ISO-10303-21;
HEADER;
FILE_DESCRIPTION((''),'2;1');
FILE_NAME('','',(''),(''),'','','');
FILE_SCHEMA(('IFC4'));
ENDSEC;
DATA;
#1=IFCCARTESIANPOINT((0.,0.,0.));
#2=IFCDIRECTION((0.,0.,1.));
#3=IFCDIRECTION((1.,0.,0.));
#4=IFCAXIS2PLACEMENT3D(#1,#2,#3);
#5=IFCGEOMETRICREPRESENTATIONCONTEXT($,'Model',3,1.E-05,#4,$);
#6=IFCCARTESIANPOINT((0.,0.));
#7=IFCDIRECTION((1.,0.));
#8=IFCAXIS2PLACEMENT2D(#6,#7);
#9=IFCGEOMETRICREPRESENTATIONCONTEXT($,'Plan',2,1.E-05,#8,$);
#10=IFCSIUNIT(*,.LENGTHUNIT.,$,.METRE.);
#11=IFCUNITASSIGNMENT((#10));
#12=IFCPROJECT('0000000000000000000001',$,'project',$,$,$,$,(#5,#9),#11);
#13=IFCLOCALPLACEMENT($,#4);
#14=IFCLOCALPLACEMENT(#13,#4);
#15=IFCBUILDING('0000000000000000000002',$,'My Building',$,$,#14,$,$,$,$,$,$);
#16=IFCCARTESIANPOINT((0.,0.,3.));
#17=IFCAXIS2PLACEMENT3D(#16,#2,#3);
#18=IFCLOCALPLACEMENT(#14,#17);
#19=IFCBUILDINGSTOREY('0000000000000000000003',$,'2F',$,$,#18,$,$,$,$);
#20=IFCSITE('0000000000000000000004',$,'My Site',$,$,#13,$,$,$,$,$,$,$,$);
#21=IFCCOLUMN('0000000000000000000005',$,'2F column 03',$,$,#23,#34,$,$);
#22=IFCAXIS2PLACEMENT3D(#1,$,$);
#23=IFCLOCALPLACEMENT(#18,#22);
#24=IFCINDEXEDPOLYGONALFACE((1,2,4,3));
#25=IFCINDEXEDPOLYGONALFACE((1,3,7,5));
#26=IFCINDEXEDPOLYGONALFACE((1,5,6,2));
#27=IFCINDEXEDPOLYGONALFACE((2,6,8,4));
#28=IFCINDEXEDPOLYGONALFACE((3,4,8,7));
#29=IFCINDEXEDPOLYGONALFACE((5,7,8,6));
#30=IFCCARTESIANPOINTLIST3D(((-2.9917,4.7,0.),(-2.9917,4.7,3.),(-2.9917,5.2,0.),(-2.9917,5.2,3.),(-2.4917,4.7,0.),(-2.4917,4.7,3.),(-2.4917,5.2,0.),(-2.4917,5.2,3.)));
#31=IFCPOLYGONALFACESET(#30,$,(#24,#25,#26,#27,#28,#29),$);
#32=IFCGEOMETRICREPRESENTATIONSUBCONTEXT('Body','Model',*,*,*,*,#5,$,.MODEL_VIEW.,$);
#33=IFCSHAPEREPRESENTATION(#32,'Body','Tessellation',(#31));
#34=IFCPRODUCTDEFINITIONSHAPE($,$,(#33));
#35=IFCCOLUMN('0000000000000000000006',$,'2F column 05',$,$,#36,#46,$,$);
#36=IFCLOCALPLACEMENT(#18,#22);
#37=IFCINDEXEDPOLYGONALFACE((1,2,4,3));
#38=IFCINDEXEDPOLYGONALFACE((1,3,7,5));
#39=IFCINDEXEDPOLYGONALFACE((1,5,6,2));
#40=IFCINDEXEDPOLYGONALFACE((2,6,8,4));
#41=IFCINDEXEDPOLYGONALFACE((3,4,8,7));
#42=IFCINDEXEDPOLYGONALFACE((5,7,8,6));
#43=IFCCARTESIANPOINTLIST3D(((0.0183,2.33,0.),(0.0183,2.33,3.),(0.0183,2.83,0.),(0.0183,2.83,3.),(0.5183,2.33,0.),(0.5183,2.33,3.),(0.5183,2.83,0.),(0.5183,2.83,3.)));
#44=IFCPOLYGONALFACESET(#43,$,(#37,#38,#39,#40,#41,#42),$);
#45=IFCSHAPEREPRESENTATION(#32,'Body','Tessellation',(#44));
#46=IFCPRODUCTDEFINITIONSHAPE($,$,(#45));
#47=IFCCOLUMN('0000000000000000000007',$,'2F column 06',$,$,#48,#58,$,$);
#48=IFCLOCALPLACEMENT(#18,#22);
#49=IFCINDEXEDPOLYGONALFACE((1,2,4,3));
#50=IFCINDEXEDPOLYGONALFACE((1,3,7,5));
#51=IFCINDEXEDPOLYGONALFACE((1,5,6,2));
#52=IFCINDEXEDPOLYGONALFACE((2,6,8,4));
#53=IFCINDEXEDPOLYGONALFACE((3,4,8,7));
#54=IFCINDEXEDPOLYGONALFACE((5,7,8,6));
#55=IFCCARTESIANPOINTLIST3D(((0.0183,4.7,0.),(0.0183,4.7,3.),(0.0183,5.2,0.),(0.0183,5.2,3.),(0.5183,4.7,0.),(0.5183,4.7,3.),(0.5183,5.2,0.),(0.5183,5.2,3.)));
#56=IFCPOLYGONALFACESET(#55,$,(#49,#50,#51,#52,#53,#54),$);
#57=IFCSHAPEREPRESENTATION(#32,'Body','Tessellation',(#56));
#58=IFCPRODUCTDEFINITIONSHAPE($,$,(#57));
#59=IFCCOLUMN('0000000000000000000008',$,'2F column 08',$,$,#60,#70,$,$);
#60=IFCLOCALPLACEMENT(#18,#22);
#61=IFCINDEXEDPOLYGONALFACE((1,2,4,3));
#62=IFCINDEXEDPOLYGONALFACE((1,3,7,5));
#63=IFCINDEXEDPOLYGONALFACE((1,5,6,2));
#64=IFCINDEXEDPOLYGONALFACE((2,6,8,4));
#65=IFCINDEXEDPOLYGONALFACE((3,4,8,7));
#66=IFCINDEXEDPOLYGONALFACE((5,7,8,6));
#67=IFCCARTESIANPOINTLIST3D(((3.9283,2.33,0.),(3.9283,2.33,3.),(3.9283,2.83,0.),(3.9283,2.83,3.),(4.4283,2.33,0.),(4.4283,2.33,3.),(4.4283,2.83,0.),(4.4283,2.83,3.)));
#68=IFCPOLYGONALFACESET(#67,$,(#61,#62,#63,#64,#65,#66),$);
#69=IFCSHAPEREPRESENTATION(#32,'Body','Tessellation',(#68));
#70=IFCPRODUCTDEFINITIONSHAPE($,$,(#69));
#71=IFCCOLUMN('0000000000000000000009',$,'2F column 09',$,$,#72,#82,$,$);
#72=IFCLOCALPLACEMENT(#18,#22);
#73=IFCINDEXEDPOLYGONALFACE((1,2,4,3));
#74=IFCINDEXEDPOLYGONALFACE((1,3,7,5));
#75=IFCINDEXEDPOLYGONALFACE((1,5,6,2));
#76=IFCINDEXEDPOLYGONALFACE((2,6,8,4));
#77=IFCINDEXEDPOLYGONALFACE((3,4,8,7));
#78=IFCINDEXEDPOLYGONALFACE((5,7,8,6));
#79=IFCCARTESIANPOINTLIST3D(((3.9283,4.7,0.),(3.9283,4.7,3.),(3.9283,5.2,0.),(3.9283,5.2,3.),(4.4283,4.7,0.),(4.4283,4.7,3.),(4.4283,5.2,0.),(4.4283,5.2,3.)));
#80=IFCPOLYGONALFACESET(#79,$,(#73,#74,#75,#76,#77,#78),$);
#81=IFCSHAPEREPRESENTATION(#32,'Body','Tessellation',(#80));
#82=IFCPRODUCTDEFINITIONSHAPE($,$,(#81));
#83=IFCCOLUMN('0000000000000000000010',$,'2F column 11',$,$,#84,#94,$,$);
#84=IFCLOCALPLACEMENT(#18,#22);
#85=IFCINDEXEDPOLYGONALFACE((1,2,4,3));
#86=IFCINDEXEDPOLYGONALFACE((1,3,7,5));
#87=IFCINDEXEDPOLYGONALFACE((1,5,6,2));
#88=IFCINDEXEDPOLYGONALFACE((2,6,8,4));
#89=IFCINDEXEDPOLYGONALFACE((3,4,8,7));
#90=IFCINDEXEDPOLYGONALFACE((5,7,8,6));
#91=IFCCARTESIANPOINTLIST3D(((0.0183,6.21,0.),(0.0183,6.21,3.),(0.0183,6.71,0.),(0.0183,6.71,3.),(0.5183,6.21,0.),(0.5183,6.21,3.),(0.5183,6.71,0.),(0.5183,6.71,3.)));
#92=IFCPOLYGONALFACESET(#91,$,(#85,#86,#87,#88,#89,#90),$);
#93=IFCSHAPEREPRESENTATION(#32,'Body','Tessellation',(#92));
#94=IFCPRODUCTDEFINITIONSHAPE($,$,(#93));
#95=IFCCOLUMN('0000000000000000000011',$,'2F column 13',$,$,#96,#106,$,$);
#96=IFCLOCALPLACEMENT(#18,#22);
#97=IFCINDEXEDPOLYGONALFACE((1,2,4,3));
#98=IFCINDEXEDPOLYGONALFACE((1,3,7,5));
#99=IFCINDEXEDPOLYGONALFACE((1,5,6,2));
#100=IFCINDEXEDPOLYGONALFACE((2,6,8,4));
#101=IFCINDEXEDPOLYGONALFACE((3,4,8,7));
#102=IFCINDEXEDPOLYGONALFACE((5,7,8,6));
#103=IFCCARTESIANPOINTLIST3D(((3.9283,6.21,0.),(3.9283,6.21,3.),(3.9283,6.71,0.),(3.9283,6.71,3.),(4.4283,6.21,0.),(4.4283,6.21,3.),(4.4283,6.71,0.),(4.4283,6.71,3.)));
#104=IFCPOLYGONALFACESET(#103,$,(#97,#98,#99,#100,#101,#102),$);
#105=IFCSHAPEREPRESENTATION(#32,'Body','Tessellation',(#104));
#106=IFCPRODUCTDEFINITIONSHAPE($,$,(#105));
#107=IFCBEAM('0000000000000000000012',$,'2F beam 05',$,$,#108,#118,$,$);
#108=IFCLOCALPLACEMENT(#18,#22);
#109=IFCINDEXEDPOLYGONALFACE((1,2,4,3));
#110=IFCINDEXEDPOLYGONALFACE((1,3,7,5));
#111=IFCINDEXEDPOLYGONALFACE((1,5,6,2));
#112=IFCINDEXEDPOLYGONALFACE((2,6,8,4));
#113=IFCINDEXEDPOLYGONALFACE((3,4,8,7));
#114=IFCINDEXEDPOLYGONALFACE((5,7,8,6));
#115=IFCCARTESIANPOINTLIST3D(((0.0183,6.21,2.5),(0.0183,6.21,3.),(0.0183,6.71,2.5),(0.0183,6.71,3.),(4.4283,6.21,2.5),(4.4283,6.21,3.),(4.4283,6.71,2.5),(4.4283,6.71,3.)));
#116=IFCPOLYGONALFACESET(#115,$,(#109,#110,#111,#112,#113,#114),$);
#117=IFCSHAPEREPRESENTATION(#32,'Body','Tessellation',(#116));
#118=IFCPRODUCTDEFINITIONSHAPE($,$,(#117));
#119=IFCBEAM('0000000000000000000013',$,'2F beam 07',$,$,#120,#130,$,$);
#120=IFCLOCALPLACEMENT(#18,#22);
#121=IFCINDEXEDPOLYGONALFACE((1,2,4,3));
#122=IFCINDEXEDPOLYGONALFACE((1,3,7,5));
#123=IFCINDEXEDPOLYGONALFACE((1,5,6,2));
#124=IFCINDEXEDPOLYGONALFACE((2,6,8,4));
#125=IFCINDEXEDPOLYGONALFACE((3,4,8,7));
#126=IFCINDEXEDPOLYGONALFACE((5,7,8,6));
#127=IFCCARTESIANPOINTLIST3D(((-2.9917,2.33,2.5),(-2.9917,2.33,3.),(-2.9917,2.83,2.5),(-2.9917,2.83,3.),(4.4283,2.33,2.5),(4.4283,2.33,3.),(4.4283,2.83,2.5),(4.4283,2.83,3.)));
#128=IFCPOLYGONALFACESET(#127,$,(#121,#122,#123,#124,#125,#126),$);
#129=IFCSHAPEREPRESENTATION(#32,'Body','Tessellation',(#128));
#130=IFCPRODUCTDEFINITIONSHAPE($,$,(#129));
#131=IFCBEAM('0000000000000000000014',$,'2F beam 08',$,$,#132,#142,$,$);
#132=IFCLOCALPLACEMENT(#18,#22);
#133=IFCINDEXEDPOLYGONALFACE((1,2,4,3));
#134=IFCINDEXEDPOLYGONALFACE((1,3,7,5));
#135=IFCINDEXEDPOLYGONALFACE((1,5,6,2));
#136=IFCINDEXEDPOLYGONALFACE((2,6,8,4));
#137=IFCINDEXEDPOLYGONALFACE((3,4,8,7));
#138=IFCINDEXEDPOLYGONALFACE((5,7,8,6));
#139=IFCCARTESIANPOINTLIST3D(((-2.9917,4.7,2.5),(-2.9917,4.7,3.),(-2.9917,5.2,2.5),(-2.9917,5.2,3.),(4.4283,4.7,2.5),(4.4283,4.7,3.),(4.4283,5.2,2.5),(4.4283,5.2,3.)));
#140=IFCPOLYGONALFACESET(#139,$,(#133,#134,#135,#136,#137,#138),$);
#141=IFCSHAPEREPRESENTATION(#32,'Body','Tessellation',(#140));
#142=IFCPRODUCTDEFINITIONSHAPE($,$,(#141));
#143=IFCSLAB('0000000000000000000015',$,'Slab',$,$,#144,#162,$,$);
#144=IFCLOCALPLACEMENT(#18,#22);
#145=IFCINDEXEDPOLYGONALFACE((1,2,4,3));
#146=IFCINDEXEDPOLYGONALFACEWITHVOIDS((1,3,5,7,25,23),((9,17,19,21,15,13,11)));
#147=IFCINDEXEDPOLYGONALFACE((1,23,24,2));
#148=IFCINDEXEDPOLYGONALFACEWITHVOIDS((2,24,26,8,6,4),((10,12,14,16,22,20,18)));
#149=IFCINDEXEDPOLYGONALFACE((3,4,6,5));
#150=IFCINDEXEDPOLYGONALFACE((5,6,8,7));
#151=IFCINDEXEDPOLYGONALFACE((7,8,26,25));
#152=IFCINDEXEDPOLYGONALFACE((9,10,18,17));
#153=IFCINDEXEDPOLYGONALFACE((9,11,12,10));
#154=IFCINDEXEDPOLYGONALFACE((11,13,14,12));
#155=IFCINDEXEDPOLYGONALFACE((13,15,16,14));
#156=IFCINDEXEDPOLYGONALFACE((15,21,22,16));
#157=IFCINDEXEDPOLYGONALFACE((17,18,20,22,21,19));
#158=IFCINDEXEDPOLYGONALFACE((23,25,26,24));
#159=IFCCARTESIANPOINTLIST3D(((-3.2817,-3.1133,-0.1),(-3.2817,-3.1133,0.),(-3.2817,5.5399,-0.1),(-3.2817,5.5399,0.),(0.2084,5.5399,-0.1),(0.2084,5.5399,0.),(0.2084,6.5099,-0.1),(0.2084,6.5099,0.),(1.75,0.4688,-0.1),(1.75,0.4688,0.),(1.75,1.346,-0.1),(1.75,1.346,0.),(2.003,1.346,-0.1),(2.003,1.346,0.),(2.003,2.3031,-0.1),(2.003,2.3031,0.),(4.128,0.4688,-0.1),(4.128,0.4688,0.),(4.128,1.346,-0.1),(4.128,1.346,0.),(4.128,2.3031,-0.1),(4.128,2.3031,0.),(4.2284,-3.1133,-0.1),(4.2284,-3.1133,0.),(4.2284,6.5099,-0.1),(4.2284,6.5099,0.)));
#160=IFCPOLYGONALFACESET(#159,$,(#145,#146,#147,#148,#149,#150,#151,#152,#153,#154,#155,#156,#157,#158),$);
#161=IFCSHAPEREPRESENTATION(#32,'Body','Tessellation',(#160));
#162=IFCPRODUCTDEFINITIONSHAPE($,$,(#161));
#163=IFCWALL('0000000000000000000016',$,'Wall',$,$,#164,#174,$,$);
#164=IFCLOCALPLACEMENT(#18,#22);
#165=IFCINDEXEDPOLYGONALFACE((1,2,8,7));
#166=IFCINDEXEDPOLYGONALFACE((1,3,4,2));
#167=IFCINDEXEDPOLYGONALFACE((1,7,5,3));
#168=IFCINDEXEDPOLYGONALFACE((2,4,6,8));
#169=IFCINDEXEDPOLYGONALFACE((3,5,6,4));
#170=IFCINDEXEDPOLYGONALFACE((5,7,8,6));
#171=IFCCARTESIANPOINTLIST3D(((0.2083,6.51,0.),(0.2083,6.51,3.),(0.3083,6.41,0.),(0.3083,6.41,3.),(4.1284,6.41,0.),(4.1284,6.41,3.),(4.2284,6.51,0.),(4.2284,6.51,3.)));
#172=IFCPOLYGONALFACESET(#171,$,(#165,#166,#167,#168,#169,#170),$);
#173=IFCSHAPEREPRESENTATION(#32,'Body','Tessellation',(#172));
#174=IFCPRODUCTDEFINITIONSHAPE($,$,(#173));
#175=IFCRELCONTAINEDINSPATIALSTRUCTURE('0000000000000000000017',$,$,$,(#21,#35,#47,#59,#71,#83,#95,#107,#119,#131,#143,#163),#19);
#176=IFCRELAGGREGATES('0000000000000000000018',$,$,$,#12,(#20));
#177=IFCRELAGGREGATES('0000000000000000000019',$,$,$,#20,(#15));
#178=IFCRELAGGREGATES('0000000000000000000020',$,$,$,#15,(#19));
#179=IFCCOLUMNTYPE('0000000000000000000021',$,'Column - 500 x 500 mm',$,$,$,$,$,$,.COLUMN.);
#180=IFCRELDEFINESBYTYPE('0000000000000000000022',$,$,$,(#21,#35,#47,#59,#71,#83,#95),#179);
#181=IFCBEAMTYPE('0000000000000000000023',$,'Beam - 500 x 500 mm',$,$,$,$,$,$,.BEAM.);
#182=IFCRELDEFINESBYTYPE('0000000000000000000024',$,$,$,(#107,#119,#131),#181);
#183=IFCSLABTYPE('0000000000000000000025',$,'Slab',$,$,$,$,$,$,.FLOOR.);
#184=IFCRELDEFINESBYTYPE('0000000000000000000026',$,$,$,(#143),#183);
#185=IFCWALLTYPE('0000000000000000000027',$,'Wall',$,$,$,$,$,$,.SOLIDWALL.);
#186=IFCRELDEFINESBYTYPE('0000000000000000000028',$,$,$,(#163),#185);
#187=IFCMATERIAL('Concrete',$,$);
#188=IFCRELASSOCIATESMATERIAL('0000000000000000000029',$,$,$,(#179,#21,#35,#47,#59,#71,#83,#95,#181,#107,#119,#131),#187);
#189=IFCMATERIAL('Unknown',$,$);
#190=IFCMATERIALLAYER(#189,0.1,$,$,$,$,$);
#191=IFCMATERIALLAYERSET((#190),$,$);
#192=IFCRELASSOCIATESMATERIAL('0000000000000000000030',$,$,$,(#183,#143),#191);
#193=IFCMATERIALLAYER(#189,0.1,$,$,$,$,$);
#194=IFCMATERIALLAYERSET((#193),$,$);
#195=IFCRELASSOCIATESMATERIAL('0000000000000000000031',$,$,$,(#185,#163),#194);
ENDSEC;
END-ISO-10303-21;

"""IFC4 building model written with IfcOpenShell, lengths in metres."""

from ifc_helpers import new_model, si_unit, frame, origin_with_axes, origin_2d_with_axis, place, context, subcontext, project, spatial, line, indexed_curve, rectangle, outline, extrude, material, layer, layer_set, layer_usage, material_profile, profile_set, profile_usage, type_object, element, save


model = new_model("IFC4")

# Units and contexts
model_context = context("Model", 3, precision=1e-05, world=origin_with_axes())
plan_context = context("Plan", 2, precision=1e-05, world=origin_2d_with_axis())
body_context_1 = subcontext(model_context, "Body", "Model", "MODEL_VIEW")
ifc_project = project(units=[si_unit("LENGTHUNIT", "METRE")], contexts=[model_context, plan_context])

# Site, building, storey
site_placement = place(None, origin_with_axes())
site = spatial("IfcSite", under=ifc_project, at=site_placement, Name="My Site")
building_placement = place(site_placement, origin_with_axes())
building = spatial("IfcBuilding", under=site, at=building_placement, Name="My Building")
storey_placement = place(building_placement, frame((0.0, 0.0, 3.0), z_axis=(0.0, 0.0, 1.0), x_axis=(1.0, 0.0, 0.0)))
storey = spatial("IfcBuildingStorey", under=building, at=storey_placement, Name="2F")

# Columns
ifc_material_1 = material(Name="Concrete")
ifc_material_profile_1 = material_profile(ifc_material_1, rectangle(XDim=0.5, YDim=0.5))
ifc_profile_set_1 = profile_set([ifc_material_profile_1])
ifc_profile_usage_1 = profile_usage(ifc_profile_set_1, cardinal=5)
column_type = type_object("IfcColumnType", Name="Column - 500 x 500 mm", PredefinedType="COLUMN", material=ifc_profile_set_1)
column_1_placement = place(storey_placement, frame((-2.7417, 4.95, 0.0), z_axis=(0.0, 0.0, 1.0), x_axis=(1.0, 0.0, 0.0)))
element("IfcColumn", 1, at=column_1_placement, inside=storey, type_object=column_type, material=ifc_profile_usage_1, Name="2F column 03", context=body_context_1, shape_type="SweptSolid", body=[
    extrude(rectangle(XDim=0.5, YDim=0.5), origin_with_axes(), (0.0, 0.0, 1.0), 3.0),
])
ifc_profile_usage_2 = profile_usage(ifc_profile_set_1, cardinal=5)
column_2_placement = place(storey_placement, frame((0.2683, 2.58, 0.0), z_axis=(0.0, 0.0, 1.0), x_axis=(1.0, 0.0, 0.0)))
element("IfcColumn", 2, at=column_2_placement, inside=storey, type_object=column_type, material=ifc_profile_usage_2, Name="2F column 05", context=body_context_1, shape_type="SweptSolid", body=[
    extrude(rectangle(XDim=0.5, YDim=0.5), origin_with_axes(), (0.0, 0.0, 1.0), 3.0),
])
ifc_profile_usage_3 = profile_usage(ifc_profile_set_1, cardinal=5)
column_3_placement = place(storey_placement, frame((0.2683, 4.95, 0.0), z_axis=(0.0, 0.0, 1.0), x_axis=(1.0, 0.0, 0.0)))
element("IfcColumn", 3, at=column_3_placement, inside=storey, type_object=column_type, material=ifc_profile_usage_3, Name="2F column 06", context=body_context_1, shape_type="SweptSolid", body=[
    extrude(rectangle(XDim=0.5, YDim=0.5), origin_with_axes(), (0.0, 0.0, 1.0), 3.0),
])
ifc_profile_usage_4 = profile_usage(ifc_profile_set_1, cardinal=5)
column_4_placement = place(storey_placement, frame((4.1783, 2.58, 0.0), z_axis=(0.0, 0.0, 1.0), x_axis=(1.0, 0.0, 0.0)))
element("IfcColumn", 4, at=column_4_placement, inside=storey, type_object=column_type, material=ifc_profile_usage_4, Name="2F column 08", context=body_context_1, shape_type="SweptSolid", body=[
    extrude(rectangle(XDim=0.5, YDim=0.5), origin_with_axes(), (0.0, 0.0, 1.0), 3.0),
])
ifc_profile_usage_5 = profile_usage(ifc_profile_set_1, cardinal=5)
column_5_placement = place(storey_placement, frame((4.1783, 4.95, 0.0), z_axis=(0.0, 0.0, 1.0), x_axis=(1.0, 0.0, 0.0)))
element("IfcColumn", 5, at=column_5_placement, inside=storey, type_object=column_type, material=ifc_profile_usage_5, Name="2F column 09", context=body_context_1, shape_type="SweptSolid", body=[
    extrude(rectangle(XDim=0.5, YDim=0.5), origin_with_axes(), (0.0, 0.0, 1.0), 3.0),
])
ifc_profile_usage_6 = profile_usage(ifc_profile_set_1, cardinal=5)
column_6_placement = place(storey_placement, frame((0.2683, 6.46, 0.0), z_axis=(0.0, 0.0, 1.0), x_axis=(1.0, 0.0, 0.0)))
element("IfcColumn", 6, at=column_6_placement, inside=storey, type_object=column_type, material=ifc_profile_usage_6, Name="2F column 11", context=body_context_1, shape_type="SweptSolid", body=[
    extrude(rectangle(XDim=0.5, YDim=0.5), origin_with_axes(), (0.0, 0.0, 1.0), 3.0),
])
ifc_profile_usage_7 = profile_usage(ifc_profile_set_1, cardinal=5)
column_7_placement = place(storey_placement, frame((4.1783, 6.46, 0.0), z_axis=(0.0, 0.0, 1.0), x_axis=(1.0, 0.0, 0.0)))
element("IfcColumn", 7, at=column_7_placement, inside=storey, type_object=column_type, material=ifc_profile_usage_7, Name="2F column 13", context=body_context_1, shape_type="SweptSolid", body=[
    extrude(rectangle(XDim=0.5, YDim=0.5), origin_with_axes(), (0.0, 0.0, 1.0), 3.0),
])

# Beams
ifc_material_profile_2 = material_profile(ifc_material_1, rectangle(XDim=0.5, YDim=0.5))
ifc_profile_set_2 = profile_set([ifc_material_profile_2])
ifc_profile_usage_8 = profile_usage(ifc_profile_set_2, cardinal=5)
beam_type = type_object("IfcBeamType", Name="Beam - 500 x 500 mm", PredefinedType="BEAM", material=ifc_profile_set_2)
beam_1_placement = place(storey_placement, frame((0.0183, 6.46, 2.75), z_axis=(1.0, 0.0, 0.0), x_axis=(0.0, 0.0, 1.0)))
element("IfcBeam", 8, at=beam_1_placement, inside=storey, type_object=beam_type, material=ifc_profile_usage_8, Name="2F beam 05", context=body_context_1, shape_type="SweptSolid", body=[
    extrude(rectangle(XDim=0.5, YDim=0.5), origin_with_axes(), (0.0, 0.0, 1.0), 4.41),
])
ifc_profile_usage_9 = profile_usage(ifc_profile_set_2, cardinal=5)
beam_2_placement = place(storey_placement, frame((-2.9917, 2.58, 2.75), z_axis=(1.0, 0.0, 0.0), x_axis=(0.0, 0.0, 1.0)))
element("IfcBeam", 9, at=beam_2_placement, inside=storey, type_object=beam_type, material=ifc_profile_usage_9, Name="2F beam 07", context=body_context_1, shape_type="SweptSolid", body=[
    extrude(rectangle(XDim=0.5, YDim=0.5), origin_with_axes(), (0.0, 0.0, 1.0), 7.42),
])
ifc_profile_usage_10 = profile_usage(ifc_profile_set_2, cardinal=5)
beam_3_placement = place(storey_placement, frame((-2.9917, 4.95, 2.75), z_axis=(1.0, 0.0, 0.0), x_axis=(0.0, 0.0, 1.0)))
element("IfcBeam", 10, at=beam_3_placement, inside=storey, type_object=beam_type, material=ifc_profile_usage_10, Name="2F beam 08", context=body_context_1, shape_type="SweptSolid", body=[
    extrude(rectangle(XDim=0.5, YDim=0.5), origin_with_axes(), (0.0, 0.0, 1.0), 7.42),
])

# Slab, openings
ifc_material_2 = material(Name="Unknown")
ifc_layer_1 = layer(ifc_material_2, 0.1)
ifc_layer_set_1 = layer_set([ifc_layer_1])
ifc_layer_usage_1 = layer_usage(ifc_layer_set_1, "AXIS3", "POSITIVE", -0.1)
slab_type = type_object("IfcSlabType", Name="Slab", PredefinedType="FLOOR", material=ifc_layer_set_1)
slab_placement = place(storey_placement, frame((4.2284, 6.5099, 0.0), z_axis=(0.0, 0.0, 1.0), x_axis=(1.0, 0.0, 0.0)))
slab = element("IfcSlab", 11, at=slab_placement, inside=storey, type_object=slab_type, material=ifc_layer_usage_1, Name="Slab", context=body_context_1, shape_type="SweptSolid", body=[
    extrude(outline(indexed_curve([(0.0, 0.0), (-4.02, 0.0), (-4.02, -0.97), (-7.5101, -0.97), (-7.5101, -9.6233), (0.0, -9.6233), (0.0, 0.0)])), frame((0.0, 0.0, -0.1), z_axis=(0.0, 0.0, 1.0), x_axis=(1.0, 0.0, 0.0)), (0.0, 0.0, 1.0), 0.1),
])
opening_1_placement = place(slab_placement, frame((-4.2284, -6.5099, -0.2), z_axis=(0.0, 0.0, 1.0), x_axis=(1.0, 0.0, 0.0)))
element("IfcOpeningElement", 12, at=opening_1_placement, cuts=slab, PredefinedType="OPENING", context=body_context_1, shape_type="SweptSolid", body=[
    extrude(outline(indexed_curve([(1.75, 0.4688), (4.128, 0.4688), (4.128, 1.346), (1.75, 1.346), (1.75, 0.4688)])), origin_with_axes(), (0.0, 0.0, 1.0), 0.4),
])
opening_2_placement = place(slab_placement, frame((-4.2284, -6.5099, -0.2), z_axis=(0.0, 0.0, 1.0), x_axis=(1.0, 0.0, 0.0)))
element("IfcOpeningElement", 13, at=opening_2_placement, cuts=slab, PredefinedType="OPENING", context=body_context_1, shape_type="SweptSolid", body=[
    extrude(outline(indexed_curve([(2.003, 1.346), (4.128, 1.346), (4.128, 2.3031), (2.003, 2.3031), (2.003, 1.346)])), origin_with_axes(), (0.0, 0.0, 1.0), 0.4),
])

# Wall
ifc_layer_2 = layer(ifc_material_2, 0.1)
ifc_layer_set_2 = layer_set([ifc_layer_2])
ifc_layer_usage_2 = layer_usage(ifc_layer_set_2, "AXIS2", "POSITIVE", 0.0)
wall_type = type_object("IfcWallType", Name="Wall", PredefinedType="SOLIDWALL", material=ifc_layer_set_2)
wall_1_placement = place(storey_placement, frame((4.2284, 6.51, 0.0), z_axis=(0.0, 0.0, 1.0), x_axis=(-1.0, 0.0, 0.0)))
element("IfcWall", 14, at=wall_1_placement, inside=storey, type_object=wall_type, material=ifc_layer_usage_2, Name="Wall", context=body_context_1, shape_type="SweptSolid", body=[
    extrude(outline(indexed_curve([(0.0, 0.0), (0.1, 0.1), (3.92, 0.1), (4.02, 0.0)], segments=[line(1, 2, 3, 4, 1)])), origin_with_axes(), (0.0, 0.0, 1.0), 3.0),
])

save(model, "model.ifc")
